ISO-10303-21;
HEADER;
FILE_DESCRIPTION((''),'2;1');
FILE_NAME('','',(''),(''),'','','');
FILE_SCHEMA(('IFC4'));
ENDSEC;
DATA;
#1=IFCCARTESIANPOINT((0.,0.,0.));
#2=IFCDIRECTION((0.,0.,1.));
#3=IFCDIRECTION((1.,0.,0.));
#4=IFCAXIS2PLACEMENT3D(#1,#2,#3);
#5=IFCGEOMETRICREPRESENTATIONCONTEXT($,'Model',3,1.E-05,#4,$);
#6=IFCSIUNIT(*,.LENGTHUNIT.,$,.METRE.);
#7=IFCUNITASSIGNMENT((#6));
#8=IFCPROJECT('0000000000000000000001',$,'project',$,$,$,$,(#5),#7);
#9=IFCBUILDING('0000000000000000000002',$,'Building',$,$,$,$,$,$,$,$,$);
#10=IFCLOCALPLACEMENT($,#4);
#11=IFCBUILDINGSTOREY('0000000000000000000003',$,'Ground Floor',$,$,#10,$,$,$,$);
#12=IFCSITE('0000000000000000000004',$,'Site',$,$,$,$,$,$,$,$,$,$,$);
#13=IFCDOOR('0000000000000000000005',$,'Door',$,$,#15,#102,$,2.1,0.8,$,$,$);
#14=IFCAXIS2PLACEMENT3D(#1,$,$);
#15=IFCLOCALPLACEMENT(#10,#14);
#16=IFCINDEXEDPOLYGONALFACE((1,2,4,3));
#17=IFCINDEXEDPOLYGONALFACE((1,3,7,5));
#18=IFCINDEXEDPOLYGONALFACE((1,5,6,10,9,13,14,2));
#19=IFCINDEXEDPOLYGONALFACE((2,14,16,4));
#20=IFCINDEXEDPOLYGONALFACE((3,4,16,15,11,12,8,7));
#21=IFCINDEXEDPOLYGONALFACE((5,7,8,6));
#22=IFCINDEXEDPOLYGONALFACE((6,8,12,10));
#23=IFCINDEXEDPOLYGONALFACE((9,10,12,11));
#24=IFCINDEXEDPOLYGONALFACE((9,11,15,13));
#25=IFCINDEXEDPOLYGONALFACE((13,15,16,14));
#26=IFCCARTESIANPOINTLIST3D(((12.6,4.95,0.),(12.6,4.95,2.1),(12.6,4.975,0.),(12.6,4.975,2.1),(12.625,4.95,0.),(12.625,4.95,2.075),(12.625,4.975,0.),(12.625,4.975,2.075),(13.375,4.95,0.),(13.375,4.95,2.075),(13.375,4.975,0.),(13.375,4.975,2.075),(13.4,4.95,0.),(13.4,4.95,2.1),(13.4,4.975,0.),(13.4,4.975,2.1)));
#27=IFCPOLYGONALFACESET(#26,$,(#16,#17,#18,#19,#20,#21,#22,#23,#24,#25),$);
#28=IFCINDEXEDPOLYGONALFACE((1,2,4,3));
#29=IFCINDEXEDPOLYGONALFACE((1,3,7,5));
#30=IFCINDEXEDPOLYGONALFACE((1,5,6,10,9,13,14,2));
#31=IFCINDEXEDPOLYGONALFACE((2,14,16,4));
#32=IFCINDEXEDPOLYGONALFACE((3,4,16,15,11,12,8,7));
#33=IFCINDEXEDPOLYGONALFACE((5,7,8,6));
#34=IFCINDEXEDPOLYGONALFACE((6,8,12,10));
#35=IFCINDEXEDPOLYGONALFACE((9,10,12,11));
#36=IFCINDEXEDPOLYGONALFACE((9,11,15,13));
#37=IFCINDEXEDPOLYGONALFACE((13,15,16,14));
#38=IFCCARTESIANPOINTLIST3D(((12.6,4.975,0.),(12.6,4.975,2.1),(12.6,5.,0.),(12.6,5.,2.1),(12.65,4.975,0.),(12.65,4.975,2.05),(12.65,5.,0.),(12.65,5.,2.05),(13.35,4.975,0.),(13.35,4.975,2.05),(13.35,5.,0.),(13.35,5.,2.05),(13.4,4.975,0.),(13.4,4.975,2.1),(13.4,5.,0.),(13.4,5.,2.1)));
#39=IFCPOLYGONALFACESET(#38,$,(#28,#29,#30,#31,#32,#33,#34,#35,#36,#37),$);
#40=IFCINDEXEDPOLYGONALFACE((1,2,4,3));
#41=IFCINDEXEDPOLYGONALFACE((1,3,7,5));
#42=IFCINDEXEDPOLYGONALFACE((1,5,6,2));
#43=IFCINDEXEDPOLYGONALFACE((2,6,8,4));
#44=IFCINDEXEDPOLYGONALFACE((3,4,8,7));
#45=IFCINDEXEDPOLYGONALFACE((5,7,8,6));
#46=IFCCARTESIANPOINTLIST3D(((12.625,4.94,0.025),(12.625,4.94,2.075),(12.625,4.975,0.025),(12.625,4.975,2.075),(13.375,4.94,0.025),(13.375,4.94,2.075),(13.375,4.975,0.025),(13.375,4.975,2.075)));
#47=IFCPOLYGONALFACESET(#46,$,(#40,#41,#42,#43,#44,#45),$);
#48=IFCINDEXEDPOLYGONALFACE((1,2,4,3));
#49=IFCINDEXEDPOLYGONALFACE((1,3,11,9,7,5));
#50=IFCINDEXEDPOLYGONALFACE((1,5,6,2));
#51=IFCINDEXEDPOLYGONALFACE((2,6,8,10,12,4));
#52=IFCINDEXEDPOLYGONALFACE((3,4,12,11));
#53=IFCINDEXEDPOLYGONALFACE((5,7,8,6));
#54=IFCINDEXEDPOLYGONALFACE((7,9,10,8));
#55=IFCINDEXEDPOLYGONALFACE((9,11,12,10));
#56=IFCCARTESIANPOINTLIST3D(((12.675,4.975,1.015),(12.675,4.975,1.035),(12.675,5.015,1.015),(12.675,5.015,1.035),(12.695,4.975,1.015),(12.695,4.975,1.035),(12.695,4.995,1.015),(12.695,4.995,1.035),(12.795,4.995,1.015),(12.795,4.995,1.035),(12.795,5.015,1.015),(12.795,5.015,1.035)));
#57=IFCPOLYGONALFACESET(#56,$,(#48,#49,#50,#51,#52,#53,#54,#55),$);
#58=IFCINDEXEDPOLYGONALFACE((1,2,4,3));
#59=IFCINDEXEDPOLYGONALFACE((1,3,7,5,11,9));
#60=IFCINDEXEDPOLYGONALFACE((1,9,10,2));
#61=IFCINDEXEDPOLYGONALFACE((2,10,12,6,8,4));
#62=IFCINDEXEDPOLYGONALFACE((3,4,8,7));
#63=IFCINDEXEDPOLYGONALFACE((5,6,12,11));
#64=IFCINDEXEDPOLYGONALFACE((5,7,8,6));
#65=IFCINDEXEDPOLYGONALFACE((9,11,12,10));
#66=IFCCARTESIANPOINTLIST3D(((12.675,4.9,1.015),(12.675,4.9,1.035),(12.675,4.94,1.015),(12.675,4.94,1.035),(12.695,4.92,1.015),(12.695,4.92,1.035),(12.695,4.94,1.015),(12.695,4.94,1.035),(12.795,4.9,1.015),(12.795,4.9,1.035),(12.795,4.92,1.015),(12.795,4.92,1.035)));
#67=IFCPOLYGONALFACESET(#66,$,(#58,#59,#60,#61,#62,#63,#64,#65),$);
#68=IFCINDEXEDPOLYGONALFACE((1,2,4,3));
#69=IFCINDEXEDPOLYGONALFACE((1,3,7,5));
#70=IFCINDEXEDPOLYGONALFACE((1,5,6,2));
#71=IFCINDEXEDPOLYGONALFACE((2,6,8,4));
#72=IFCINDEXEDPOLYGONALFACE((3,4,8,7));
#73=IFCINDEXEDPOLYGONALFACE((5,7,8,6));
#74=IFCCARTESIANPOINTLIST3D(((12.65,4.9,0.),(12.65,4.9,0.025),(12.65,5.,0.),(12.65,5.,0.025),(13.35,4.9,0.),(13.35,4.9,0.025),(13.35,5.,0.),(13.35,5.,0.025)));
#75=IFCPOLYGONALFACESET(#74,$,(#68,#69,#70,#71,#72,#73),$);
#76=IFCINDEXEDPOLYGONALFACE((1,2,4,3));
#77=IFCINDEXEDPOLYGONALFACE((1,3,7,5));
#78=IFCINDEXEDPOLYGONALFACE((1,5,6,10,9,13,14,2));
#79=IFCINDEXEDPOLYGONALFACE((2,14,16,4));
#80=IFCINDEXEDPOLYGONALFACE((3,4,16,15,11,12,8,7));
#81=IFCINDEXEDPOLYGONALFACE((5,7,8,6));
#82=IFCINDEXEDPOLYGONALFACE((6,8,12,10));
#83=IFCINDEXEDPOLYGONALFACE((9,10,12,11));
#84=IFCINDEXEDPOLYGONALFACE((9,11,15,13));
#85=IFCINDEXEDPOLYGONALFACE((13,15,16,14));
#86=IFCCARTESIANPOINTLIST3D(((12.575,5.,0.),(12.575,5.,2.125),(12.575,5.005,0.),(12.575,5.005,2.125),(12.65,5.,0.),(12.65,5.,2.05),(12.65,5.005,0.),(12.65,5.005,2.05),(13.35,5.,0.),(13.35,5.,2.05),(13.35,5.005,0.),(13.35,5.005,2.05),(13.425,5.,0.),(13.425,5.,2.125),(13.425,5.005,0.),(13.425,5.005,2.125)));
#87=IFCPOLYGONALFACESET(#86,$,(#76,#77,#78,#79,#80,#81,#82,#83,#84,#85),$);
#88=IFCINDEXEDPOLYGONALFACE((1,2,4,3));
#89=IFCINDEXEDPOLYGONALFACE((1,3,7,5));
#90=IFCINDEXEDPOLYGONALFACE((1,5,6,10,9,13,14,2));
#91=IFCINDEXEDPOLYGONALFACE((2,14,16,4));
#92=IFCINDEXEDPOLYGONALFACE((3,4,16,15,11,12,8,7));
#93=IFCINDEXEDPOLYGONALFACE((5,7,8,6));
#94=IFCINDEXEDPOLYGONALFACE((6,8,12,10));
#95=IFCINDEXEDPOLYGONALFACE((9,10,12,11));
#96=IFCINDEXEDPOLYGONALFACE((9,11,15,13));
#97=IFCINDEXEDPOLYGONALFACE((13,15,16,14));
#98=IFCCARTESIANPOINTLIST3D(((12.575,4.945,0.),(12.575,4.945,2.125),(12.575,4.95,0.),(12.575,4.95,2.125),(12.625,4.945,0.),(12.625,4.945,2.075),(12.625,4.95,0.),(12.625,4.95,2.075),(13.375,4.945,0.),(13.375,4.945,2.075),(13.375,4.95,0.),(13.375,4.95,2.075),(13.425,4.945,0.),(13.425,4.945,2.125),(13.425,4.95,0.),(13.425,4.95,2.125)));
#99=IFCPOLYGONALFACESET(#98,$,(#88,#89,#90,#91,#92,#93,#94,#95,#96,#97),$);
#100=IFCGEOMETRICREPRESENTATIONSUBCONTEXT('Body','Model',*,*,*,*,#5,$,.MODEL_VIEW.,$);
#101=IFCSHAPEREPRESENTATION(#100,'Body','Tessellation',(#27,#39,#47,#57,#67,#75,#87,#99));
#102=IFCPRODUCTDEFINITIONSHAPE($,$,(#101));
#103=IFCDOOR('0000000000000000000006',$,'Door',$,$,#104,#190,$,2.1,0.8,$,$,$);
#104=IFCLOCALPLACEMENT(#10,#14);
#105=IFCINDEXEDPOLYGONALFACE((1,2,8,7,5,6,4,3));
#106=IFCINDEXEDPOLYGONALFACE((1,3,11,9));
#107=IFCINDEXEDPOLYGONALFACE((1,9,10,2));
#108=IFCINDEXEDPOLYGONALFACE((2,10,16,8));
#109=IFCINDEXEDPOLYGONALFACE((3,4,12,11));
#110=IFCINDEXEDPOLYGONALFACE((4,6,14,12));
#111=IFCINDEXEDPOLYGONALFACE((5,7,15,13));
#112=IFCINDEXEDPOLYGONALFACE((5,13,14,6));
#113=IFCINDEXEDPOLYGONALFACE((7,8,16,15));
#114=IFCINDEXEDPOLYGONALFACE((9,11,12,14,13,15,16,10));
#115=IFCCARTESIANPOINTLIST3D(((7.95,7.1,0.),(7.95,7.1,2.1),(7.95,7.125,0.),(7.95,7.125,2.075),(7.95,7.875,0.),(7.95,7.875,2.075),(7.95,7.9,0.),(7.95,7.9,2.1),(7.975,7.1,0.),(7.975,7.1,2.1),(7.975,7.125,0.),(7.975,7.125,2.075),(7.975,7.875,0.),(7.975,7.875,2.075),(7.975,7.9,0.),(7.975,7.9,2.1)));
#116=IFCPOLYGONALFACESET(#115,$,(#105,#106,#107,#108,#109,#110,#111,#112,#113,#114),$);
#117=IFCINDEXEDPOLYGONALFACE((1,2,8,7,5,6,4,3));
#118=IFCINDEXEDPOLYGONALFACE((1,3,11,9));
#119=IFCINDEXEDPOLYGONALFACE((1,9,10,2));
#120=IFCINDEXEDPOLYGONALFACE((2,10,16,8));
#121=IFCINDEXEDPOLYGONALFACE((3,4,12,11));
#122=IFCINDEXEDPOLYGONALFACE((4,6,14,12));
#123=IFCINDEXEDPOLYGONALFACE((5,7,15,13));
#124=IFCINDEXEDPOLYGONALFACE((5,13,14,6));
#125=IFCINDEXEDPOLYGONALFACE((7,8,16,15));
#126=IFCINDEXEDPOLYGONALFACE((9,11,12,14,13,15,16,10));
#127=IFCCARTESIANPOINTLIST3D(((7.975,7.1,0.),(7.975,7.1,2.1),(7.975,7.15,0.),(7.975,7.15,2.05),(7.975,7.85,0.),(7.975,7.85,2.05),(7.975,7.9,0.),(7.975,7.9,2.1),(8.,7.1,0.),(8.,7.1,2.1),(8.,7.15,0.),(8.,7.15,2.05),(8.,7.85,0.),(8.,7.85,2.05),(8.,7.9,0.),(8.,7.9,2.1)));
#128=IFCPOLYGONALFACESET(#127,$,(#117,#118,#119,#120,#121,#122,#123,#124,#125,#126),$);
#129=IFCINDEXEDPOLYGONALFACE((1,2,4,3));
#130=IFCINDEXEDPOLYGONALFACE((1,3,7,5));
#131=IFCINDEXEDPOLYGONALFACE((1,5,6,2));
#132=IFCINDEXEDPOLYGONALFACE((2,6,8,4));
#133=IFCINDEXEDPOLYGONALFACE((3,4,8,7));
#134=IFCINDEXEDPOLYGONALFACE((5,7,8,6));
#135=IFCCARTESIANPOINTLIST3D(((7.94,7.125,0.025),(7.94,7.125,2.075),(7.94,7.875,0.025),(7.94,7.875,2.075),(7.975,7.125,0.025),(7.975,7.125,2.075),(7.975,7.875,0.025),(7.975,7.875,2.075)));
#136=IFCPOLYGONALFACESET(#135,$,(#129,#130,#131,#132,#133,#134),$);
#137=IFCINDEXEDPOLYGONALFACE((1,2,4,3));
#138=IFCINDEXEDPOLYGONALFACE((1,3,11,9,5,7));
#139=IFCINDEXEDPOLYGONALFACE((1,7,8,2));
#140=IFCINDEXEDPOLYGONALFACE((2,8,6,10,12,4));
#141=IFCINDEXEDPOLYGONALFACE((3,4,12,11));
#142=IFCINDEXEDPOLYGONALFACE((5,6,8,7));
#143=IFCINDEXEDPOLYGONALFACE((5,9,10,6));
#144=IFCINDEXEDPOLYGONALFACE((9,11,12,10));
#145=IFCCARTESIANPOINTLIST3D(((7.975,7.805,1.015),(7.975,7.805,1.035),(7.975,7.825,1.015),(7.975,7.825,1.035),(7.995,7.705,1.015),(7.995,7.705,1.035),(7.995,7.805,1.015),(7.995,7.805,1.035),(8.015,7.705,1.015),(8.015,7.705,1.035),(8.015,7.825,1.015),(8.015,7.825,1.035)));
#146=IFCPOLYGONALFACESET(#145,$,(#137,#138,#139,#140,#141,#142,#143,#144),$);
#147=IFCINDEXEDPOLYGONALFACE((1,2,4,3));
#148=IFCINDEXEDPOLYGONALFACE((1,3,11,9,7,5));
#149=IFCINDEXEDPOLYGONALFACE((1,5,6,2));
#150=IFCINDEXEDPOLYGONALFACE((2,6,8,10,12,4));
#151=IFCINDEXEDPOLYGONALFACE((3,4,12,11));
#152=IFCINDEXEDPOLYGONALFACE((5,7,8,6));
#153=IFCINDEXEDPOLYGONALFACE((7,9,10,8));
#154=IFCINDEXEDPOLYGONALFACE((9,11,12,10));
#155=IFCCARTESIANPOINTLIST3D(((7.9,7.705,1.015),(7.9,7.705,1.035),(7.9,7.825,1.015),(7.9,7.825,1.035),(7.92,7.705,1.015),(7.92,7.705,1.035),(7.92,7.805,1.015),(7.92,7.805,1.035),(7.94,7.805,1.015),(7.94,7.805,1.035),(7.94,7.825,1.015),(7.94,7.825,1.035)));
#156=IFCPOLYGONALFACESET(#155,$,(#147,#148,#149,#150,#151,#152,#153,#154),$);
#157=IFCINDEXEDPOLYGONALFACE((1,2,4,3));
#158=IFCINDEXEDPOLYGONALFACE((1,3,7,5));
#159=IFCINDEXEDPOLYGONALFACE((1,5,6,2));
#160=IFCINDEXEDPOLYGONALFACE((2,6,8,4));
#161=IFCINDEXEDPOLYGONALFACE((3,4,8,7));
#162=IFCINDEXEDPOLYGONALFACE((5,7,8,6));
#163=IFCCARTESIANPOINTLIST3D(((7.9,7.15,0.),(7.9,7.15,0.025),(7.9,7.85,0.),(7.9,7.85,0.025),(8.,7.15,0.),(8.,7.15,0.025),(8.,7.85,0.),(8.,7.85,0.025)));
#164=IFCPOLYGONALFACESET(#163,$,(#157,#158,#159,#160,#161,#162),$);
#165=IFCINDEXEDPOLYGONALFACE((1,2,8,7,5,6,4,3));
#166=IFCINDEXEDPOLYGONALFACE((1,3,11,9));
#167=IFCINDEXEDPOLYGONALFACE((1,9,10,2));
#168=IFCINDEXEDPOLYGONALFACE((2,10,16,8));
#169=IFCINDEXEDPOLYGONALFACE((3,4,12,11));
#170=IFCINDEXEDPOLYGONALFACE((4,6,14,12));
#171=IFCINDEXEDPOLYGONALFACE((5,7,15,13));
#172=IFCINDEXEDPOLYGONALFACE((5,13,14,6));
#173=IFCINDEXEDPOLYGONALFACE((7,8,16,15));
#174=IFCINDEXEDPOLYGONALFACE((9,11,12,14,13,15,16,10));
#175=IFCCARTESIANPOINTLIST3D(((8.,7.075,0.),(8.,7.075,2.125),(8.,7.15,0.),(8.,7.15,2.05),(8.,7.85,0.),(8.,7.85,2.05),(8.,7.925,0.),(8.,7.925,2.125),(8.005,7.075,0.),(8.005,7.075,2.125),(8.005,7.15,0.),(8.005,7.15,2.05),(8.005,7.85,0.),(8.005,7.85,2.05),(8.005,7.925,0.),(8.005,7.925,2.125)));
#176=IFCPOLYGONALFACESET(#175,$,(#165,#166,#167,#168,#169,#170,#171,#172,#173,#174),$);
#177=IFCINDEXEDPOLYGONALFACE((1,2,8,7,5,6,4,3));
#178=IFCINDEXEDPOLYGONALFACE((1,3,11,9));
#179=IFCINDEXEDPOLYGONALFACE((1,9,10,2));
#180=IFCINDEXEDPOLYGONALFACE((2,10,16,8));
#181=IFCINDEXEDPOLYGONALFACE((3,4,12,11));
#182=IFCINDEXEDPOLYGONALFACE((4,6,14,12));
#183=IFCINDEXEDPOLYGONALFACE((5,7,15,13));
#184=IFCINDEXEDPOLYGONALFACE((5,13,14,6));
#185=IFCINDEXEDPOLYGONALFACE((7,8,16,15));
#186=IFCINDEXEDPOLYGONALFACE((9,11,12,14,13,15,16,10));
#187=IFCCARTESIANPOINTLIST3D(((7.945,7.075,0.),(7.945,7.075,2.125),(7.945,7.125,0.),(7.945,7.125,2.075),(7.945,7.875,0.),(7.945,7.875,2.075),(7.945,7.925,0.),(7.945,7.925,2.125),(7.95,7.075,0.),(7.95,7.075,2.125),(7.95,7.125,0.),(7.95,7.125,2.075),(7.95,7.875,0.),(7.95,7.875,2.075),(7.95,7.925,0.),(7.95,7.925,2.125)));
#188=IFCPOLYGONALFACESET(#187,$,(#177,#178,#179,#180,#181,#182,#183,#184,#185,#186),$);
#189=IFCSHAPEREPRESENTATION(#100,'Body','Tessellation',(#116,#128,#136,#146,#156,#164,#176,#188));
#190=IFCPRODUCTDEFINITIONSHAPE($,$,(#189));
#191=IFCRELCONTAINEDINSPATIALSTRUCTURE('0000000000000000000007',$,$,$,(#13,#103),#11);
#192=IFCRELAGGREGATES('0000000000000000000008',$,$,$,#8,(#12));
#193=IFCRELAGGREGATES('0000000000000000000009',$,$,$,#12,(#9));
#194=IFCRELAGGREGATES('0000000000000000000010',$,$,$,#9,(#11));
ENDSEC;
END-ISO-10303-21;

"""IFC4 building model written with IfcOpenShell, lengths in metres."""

from ifc_helpers import new_model, si_unit, frame, origin_with_axes, place, context, subcontext, project, spatial, line, indexed_curve, outline, extrude, element, save


model = new_model("IFC4")

# Units and contexts
model_context = context("Model", 3, precision=1e-05, world=origin_with_axes())
body_context = subcontext(model_context, "Body", "Model", "MODEL_VIEW")
ifc_project = project(units=[si_unit("LENGTHUNIT", "METRE")], contexts=[model_context])

# Site, building, storey
site = spatial("IfcSite", under=ifc_project, Name="Site")
building = spatial("IfcBuilding", under=site, Name="Building")
storey_placement = place(None, origin_with_axes())
storey = spatial("IfcBuildingStorey", under=building, at=storey_placement, Name="Ground Floor")

# Doors
door_1_placement = place(storey_placement, frame((13.4, 5.0, 0.0), z_axis=(0.0, 0.0, 1.0), x_axis=(-1.0, 0.0, 0.0)))
element("IfcDoor", 1, at=door_1_placement, inside=storey, Name="Door", OverallHeight=2.1, OverallWidth=0.8, context=body_context, shape_type="SweptSolid", body=[
    extrude(outline(indexed_curve([(0.0, 0.0), (0.0, 2.1), (0.8, 2.1), (0.8, 0.0), (0.775, 0.0), (0.775, 2.075), (0.025, 2.075), (0.025, 0.0)], segments=[line(1, 2, 3, 4, 5, 6, 7, 8, 1)])), frame((0.0, 0.025, 0.0), z_axis=(0.0, -1.0, 0.0), x_axis=(1.0, 0.0, 0.0)), (0.0, 0.0, -1.0), 0.025),
    extrude(outline(indexed_curve([(0.0, 0.0), (0.0, 2.1), (0.8, 2.1), (0.8, 0.0), (0.75, 0.0), (0.75, 2.05), (0.05, 2.05), (0.05, 0.0)], segments=[line(1, 2, 3, 4, 5, 6, 7, 8, 1)])), frame((0.0, 0.0, 0.0), z_axis=(0.0, -1.0, 0.0), x_axis=(1.0, 0.0, 0.0)), (0.0, 0.0, -1.0), 0.025),
    extrude(outline(indexed_curve([(0.0, 0.0), (0.75, 0.0), (0.75, 0.035), (0.0, 0.035)], segments=[line(1, 2, 3, 4, 1)])), frame((0.025, 0.025, 0.025), z_axis=(0.0, 0.0, 1.0), x_axis=(1.0, 0.0, 0.0)), (0.0, 0.0, 1.0), 2.05),
    extrude(outline(indexed_curve([(0.0, 0.0), (0.0, -0.04), (-0.12, -0.04), (-0.12, -0.02), (-0.02, -0.02), (-0.02, 0.0)], segments=[line(1, 2, 3, 4, 5, 6, 1)])), frame((0.725, 0.025, 1.015), z_axis=(0.0, 0.0, 1.0), x_axis=(1.0, 0.0, 0.0)), (0.0, 0.0, 1.0), 0.02),
    extrude(outline(indexed_curve([(0.0, 0.0), (0.0, 0.04), (-0.12, 0.04), (-0.12, 0.02), (-0.02, 0.02), (-0.02, 0.0)], segments=[line(1, 2, 3, 4, 5, 6, 1)])), frame((0.725, 0.06, 1.015), z_axis=(0.0, 0.0, 1.0), x_axis=(1.0, 0.0, 0.0)), (0.0, 0.0, 1.0), 0.02),
    extrude(outline(indexed_curve([(0.0, 0.0), (0.7, 0.0), (0.7, 0.1), (0.0, 0.1)], segments=[line(1, 2, 3, 4, 1)])), frame((0.05, 0.0, 0.0), z_axis=(0.0, 0.0, 1.0), x_axis=(1.0, 0.0, 0.0)), (0.0, 0.0, 1.0), 0.025),
    extrude(outline(indexed_curve([(0.0, 0.0), (0.0, 2.125), (0.85, 2.125), (0.85, 0.0), (0.775, 0.0), (0.775, 2.05), (0.075, 2.05), (0.075, 0.0)], segments=[line(1, 2, 3, 4, 5, 6, 7, 8, 1)])), frame((-0.025, -0.005, 0.0), z_axis=(0.0, -1.0, 0.0), x_axis=(1.0, 0.0, 0.0)), (0.0, 0.0, -1.0), 0.005),
    extrude(outline(indexed_curve([(0.0, 0.0), (0.0, 2.125), (0.85, 2.125), (0.85, 0.0), (0.8, 0.0), (0.8, 2.075), (0.05, 2.075), (0.05, 0.0)], segments=[line(1, 2, 3, 4, 5, 6, 7, 8, 1)])), frame((-0.025, 0.05, 0.0), z_axis=(0.0, -1.0, 0.0), x_axis=(1.0, 0.0, 0.0)), (0.0, 0.0, -1.0), 0.005),
])
door_2_placement = place(storey_placement, frame((8.0, 7.1, 0.0), z_axis=(0.0, 0.0, 1.0), x_axis=(0.0, 1.0, 0.0)))
element("IfcDoor", 2, at=door_2_placement, inside=storey, Name="Door", OverallHeight=2.1, OverallWidth=0.8, context=body_context, shape_type="SweptSolid", body=[
    extrude(outline(indexed_curve([(0.0, 0.0), (0.0, 2.1), (0.8, 2.1), (0.8, 0.0), (0.775, 0.0), (0.775, 2.075), (0.025, 2.075), (0.025, 0.0)], segments=[line(1, 2, 3, 4, 5, 6, 7, 8, 1)])), frame((0.0, 0.025, 0.0), z_axis=(0.0, -1.0, 0.0), x_axis=(1.0, 0.0, 0.0)), (0.0, 0.0, -1.0), 0.025),
    extrude(outline(indexed_curve([(0.0, 0.0), (0.0, 2.1), (0.8, 2.1), (0.8, 0.0), (0.75, 0.0), (0.75, 2.05), (0.05, 2.05), (0.05, 0.0)], segments=[line(1, 2, 3, 4, 5, 6, 7, 8, 1)])), frame((0.0, 0.0, 0.0), z_axis=(0.0, -1.0, 0.0), x_axis=(1.0, 0.0, 0.0)), (0.0, 0.0, -1.0), 0.025),
    extrude(outline(indexed_curve([(0.0, 0.0), (0.75, 0.0), (0.75, 0.035), (0.0, 0.035)], segments=[line(1, 2, 3, 4, 1)])), frame((0.025, 0.025, 0.025), z_axis=(0.0, 0.0, 1.0), x_axis=(1.0, 0.0, 0.0)), (0.0, 0.0, 1.0), 2.05),
    extrude(outline(indexed_curve([(0.0, 0.0), (0.0, -0.04), (-0.12, -0.04), (-0.12, -0.02), (-0.02, -0.02), (-0.02, 0.0)], segments=[line(1, 2, 3, 4, 5, 6, 1)])), frame((0.725, 0.025, 1.015), z_axis=(0.0, 0.0, 1.0), x_axis=(1.0, 0.0, 0.0)), (0.0, 0.0, 1.0), 0.02),
    extrude(outline(indexed_curve([(0.0, 0.0), (0.0, 0.04), (-0.12, 0.04), (-0.12, 0.02), (-0.02, 0.02), (-0.02, 0.0)], segments=[line(1, 2, 3, 4, 5, 6, 1)])), frame((0.725, 0.06, 1.015), z_axis=(0.0, 0.0, 1.0), x_axis=(1.0, 0.0, 0.0)), (0.0, 0.0, 1.0), 0.02),
    extrude(outline(indexed_curve([(0.0, 0.0), (0.7, 0.0), (0.7, 0.1), (0.0, 0.1)], segments=[line(1, 2, 3, 4, 1)])), frame((0.05, 0.0, 0.0), z_axis=(0.0, 0.0, 1.0), x_axis=(1.0, 0.0, 0.0)), (0.0, 0.0, 1.0), 0.025),
    extrude(outline(indexed_curve([(0.0, 0.0), (0.0, 2.125), (0.85, 2.125), (0.85, 0.0), (0.775, 0.0), (0.775, 2.05), (0.075, 2.05), (0.075, 0.0)], segments=[line(1, 2, 3, 4, 5, 6, 7, 8, 1)])), frame((-0.025, -0.005, 0.0), z_axis=(0.0, -1.0, 0.0), x_axis=(1.0, 0.0, 0.0)), (0.0, 0.0, -1.0), 0.005),
    extrude(outline(indexed_curve([(0.0, 0.0), (0.0, 2.125), (0.85, 2.125), (0.85, 0.0), (0.8, 0.0), (0.8, 2.075), (0.05, 2.075), (0.05, 0.0)], segments=[line(1, 2, 3, 4, 5, 6, 7, 8, 1)])), frame((-0.025, 0.05, 0.0), z_axis=(0.0, -1.0, 0.0), x_axis=(1.0, 0.0, 0.0)), (0.0, 0.0, -1.0), 0.005),
])

save(model, "model.ifc")
